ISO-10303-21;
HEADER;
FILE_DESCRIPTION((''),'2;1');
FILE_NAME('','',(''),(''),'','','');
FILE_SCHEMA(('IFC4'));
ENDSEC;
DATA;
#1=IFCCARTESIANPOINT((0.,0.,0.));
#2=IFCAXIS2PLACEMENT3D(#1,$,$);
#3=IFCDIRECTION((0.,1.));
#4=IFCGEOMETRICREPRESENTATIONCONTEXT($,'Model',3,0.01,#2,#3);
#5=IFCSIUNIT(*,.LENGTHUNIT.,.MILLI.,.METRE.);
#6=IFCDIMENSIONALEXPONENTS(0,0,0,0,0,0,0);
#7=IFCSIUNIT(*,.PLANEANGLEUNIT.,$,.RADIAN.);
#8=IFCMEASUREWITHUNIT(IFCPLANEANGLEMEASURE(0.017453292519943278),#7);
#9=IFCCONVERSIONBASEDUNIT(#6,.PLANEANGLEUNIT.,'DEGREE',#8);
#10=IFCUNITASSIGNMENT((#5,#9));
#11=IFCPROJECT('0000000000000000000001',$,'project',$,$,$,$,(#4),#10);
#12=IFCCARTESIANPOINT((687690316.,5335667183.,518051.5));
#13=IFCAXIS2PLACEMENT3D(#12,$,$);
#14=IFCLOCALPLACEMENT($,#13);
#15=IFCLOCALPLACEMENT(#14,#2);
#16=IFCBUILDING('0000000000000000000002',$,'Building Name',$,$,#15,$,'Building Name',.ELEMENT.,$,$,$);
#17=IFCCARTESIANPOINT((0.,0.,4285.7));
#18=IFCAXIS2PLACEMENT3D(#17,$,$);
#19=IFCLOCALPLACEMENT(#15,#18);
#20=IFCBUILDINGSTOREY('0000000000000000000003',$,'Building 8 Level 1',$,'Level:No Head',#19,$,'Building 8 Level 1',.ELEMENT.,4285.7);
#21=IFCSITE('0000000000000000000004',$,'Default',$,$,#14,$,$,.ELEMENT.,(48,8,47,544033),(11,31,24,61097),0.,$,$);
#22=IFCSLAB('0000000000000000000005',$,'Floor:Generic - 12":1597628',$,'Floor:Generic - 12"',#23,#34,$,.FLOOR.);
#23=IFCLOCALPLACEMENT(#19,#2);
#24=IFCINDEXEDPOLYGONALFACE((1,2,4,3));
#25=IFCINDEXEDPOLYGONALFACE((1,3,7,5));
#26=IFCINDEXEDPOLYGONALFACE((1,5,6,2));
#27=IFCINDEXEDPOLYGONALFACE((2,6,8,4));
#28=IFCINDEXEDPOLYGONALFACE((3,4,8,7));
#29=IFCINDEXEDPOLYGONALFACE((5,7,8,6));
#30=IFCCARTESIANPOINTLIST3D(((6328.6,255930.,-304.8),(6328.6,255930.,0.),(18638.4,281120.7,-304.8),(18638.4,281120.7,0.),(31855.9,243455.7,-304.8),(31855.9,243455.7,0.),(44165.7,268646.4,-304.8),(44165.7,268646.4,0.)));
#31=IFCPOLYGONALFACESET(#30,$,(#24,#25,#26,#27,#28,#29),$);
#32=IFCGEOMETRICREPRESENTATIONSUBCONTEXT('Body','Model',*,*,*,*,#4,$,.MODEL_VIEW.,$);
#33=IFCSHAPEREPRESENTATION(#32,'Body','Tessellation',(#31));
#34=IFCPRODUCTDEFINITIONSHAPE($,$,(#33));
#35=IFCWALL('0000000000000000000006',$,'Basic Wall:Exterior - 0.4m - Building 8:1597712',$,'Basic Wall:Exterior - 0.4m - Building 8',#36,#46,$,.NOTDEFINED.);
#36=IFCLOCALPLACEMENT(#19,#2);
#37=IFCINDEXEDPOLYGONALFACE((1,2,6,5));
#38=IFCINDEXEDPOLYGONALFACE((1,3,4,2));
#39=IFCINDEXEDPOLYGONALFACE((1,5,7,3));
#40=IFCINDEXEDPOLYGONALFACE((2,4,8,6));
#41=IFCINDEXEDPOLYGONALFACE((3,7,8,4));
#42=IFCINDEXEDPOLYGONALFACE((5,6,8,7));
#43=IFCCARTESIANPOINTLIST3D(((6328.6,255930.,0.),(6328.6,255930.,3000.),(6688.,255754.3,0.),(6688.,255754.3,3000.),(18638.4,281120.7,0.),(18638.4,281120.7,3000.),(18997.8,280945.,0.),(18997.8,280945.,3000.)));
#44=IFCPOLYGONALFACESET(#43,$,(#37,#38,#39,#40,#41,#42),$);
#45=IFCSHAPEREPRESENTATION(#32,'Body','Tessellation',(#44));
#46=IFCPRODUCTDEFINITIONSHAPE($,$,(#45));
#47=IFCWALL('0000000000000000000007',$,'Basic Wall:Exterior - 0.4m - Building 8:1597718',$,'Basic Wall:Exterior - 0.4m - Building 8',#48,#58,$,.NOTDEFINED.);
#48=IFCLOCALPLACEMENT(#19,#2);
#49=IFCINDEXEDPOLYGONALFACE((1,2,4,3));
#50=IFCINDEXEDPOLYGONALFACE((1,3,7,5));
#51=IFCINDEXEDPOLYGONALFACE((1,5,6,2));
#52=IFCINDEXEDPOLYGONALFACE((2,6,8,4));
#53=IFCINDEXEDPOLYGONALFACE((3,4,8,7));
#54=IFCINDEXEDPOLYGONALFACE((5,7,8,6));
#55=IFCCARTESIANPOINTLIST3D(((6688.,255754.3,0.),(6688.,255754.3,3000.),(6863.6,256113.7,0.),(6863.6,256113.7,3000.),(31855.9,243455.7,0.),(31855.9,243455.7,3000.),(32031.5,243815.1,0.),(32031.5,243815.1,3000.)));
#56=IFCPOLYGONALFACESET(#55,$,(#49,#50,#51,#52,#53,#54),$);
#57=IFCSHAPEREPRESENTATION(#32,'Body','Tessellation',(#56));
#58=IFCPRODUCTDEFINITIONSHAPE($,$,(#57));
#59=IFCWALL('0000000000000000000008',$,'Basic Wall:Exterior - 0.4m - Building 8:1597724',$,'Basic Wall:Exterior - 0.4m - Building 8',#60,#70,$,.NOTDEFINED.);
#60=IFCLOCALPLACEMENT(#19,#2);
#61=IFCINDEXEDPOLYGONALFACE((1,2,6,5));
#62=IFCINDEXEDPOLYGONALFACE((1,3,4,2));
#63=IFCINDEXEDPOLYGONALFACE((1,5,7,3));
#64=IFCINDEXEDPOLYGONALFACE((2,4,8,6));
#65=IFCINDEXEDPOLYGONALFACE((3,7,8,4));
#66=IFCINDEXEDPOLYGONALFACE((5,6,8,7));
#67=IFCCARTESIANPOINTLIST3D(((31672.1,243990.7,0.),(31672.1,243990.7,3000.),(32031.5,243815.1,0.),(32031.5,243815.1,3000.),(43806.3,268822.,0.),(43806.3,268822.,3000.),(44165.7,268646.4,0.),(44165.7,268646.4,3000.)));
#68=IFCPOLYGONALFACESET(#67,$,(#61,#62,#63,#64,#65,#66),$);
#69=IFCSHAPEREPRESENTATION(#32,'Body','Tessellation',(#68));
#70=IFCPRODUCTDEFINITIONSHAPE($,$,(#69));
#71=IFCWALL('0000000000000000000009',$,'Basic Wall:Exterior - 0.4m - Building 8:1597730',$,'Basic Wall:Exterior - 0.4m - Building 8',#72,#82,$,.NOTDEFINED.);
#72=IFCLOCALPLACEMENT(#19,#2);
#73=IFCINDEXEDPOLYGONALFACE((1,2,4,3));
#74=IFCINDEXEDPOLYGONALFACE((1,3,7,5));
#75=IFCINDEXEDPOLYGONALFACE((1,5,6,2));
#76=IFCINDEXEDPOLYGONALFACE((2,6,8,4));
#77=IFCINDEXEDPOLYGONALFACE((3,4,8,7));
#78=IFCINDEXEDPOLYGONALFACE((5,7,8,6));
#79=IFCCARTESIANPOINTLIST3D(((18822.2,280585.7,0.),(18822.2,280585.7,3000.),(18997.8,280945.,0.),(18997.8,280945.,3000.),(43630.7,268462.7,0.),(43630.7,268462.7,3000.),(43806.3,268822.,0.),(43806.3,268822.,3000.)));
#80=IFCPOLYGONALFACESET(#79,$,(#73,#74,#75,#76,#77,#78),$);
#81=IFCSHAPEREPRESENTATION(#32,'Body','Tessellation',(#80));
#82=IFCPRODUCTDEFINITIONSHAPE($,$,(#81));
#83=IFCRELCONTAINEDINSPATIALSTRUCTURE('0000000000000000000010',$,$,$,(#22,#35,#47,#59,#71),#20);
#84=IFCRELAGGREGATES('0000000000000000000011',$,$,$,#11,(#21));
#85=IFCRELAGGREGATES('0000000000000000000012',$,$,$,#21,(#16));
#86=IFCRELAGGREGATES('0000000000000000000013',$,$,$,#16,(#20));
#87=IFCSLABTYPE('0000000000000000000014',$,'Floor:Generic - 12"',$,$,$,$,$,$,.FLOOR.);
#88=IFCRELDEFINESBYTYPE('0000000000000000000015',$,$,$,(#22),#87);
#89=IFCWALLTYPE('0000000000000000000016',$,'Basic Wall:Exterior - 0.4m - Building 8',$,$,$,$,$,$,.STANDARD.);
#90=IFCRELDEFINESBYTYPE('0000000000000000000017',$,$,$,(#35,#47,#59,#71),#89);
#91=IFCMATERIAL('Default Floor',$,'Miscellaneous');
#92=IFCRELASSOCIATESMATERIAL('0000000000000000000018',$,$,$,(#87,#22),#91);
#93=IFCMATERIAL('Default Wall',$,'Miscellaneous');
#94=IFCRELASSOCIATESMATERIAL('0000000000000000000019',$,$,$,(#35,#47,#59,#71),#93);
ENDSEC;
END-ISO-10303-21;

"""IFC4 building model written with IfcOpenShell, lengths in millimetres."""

from ifc_helpers import new_model, entity, si_unit, converted_unit, direction, frame, origin, place, context, subcontext, project, spatial, indexed_curve, outline, extrude, material, type_object, element, save


model = new_model("IFC4")

# Units and contexts
model_context = context("Model", 3, precision=0.01, world=origin(), true_north=direction((0.0, 1.0)))
body_context = subcontext(model_context, "Body", "Model", "MODEL_VIEW")
ifc_project = project(units=[si_unit("LENGTHUNIT", "METRE", prefix="MILLI"), converted_unit("PLANEANGLEUNIT", "DEGREE", entity("IfcPlaneAngleMeasure", 0.017453292519943278), si_unit("PLANEANGLEUNIT", "RADIAN"), dimensions=[0, 0, 0, 0, 0, 0, 0])], contexts=[model_context])

# Site, building, storey
site_placement = place(None, frame((687690316.0, 5335667183.0, 518051.5)))
site = spatial("IfcSite", under=ifc_project, at=site_placement, Name="Default", CompositionType="ELEMENT", RefLatitude=(48, 8, 47, 544033), RefLongitude=(11, 31, 24, 61097), RefElevation=0.0)
building_placement = place(site_placement, origin())
building = spatial("IfcBuilding", under=site, at=building_placement, Name="Building Name", LongName="Building Name", CompositionType="ELEMENT")
storey_placement = place(building_placement, frame((0.0, 0.0, 4285.7)))
storey = spatial("IfcBuildingStorey", under=building, at=storey_placement, Name="Building 8 Level 1", ObjectType="Level:No Head", LongName="Building 8 Level 1", CompositionType="ELEMENT", Elevation=4285.7)

# Slab
ifc_material_1 = material(Name="Default Floor", Category="Miscellaneous")
slab_type = type_object("IfcSlabType", Name="Floor:Generic - 12\"", PredefinedType="FLOOR", material=ifc_material_1)
slab_placement = place(storey_placement, origin())
element("IfcSlab", 1, at=slab_placement, inside=storey, type_object=slab_type, material=ifc_material_1, Name="Floor:Generic - 12\":1597628", ObjectType="Floor:Generic - 12\"", PredefinedType="FLOOR", context=body_context, shape_type="SweptSolid", body=[
    extrude(outline(indexed_curve([(-14018.8, -14206.1), (14018.8, -14206.1), (14018.8, 14206.1), (-14018.8, 14206.1), (-14018.8, -14206.1)], self_intersect=False)), frame((25247.1, 262288.2, 0.0), z_axis=(0.0, 0.0, -1.0), x_axis=(-0.439046, -0.898464, 0.0)), (0.0, 0.0, 1.0), 304.8),
])

# Walls
ifc_material_2 = material(Name="Default Wall", Category="Miscellaneous")
wall_type = type_object("IfcWallType", Name="Basic Wall:Exterior - 0.4m - Building 8", PredefinedType="STANDARD")
wall_1_placement = place(storey_placement, frame((18818.1, 281032.9, 0.0), z_axis=(0.0, 0.0, 1.0), x_axis=(-0.439046, -0.898464, 0.0)))
element("IfcWall", 2, at=wall_1_placement, inside=storey, type_object=wall_type, material=ifc_material_2, Name="Basic Wall:Exterior - 0.4m - Building 8:1597712", ObjectType="Basic Wall:Exterior - 0.4m - Building 8", PredefinedType="NOTDEFINED", context=body_context, shape_type="SweptSolid", body=[
    extrude(outline(indexed_curve([(28037.5, 200.0), (0.0, 200.0), (0.0, -200.0), (28037.5, -200.0), (28037.5, 200.0)], self_intersect=False)), origin(), (0.0, 0.0, 1.0), 3000.0),
])
wall_2_placement = place(storey_placement, frame((6775.8, 255934.0, 0.0), z_axis=(0.0, 0.0, 1.0), x_axis=(0.898464, -0.439046, 0.0)))
element("IfcWall", 3, at=wall_2_placement, inside=storey, type_object=wall_type, material=ifc_material_2, Name="Basic Wall:Exterior - 0.4m - Building 8:1597718", ObjectType="Basic Wall:Exterior - 0.4m - Building 8", PredefinedType="NOTDEFINED", context=body_context, shape_type="SweptSolid", body=[
    extrude(outline(indexed_curve([(28012.1, 200.0), (0.0, 200.0), (0.0, -200.0), (28012.1, -200.0), (28012.1, 200.0)], self_intersect=False)), origin(), (0.0, 0.0, 1.0), 3000.0),
])
wall_3_placement = place(storey_placement, frame((31851.8, 243902.9, 0.0), z_axis=(0.0, 0.0, 1.0), x_axis=(0.439046, 0.898464, 0.0)))
element("IfcWall", 4, at=wall_3_placement, inside=storey, type_object=wall_type, material=ifc_material_2, Name="Basic Wall:Exterior - 0.4m - Building 8:1597724", ObjectType="Basic Wall:Exterior - 0.4m - Building 8", PredefinedType="NOTDEFINED", context=body_context, shape_type="SweptSolid", body=[
    extrude(outline(indexed_curve([(27637.5, 200.0), (0.0, 200.0), (0.0, -200.0), (27637.5, -200.0), (27637.5, 200.0)], self_intersect=False)), origin(), (0.0, 0.0, 1.0), 3000.0),
])
wall_4_placement = place(storey_placement, frame((43718.5, 268642.3, 0.0), z_axis=(0.0, 0.0, 1.0), x_axis=(-0.898464, 0.439046, 0.0)))
element("IfcWall", 5, at=wall_4_placement, inside=storey, type_object=wall_type, material=ifc_material_2, Name="Basic Wall:Exterior - 0.4m - Building 8:1597730", ObjectType="Basic Wall:Exterior - 0.4m - Building 8", PredefinedType="NOTDEFINED", context=body_context, shape_type="SweptSolid", body=[
    extrude(outline(indexed_curve([(27612.1, 200.0), (0.0, 200.0), (0.0, -200.0), (27612.1, -200.0), (27612.1, 200.0)], self_intersect=False)), origin(), (0.0, 0.0, 1.0), 3000.0),
])

save(model, "model.ifc")
